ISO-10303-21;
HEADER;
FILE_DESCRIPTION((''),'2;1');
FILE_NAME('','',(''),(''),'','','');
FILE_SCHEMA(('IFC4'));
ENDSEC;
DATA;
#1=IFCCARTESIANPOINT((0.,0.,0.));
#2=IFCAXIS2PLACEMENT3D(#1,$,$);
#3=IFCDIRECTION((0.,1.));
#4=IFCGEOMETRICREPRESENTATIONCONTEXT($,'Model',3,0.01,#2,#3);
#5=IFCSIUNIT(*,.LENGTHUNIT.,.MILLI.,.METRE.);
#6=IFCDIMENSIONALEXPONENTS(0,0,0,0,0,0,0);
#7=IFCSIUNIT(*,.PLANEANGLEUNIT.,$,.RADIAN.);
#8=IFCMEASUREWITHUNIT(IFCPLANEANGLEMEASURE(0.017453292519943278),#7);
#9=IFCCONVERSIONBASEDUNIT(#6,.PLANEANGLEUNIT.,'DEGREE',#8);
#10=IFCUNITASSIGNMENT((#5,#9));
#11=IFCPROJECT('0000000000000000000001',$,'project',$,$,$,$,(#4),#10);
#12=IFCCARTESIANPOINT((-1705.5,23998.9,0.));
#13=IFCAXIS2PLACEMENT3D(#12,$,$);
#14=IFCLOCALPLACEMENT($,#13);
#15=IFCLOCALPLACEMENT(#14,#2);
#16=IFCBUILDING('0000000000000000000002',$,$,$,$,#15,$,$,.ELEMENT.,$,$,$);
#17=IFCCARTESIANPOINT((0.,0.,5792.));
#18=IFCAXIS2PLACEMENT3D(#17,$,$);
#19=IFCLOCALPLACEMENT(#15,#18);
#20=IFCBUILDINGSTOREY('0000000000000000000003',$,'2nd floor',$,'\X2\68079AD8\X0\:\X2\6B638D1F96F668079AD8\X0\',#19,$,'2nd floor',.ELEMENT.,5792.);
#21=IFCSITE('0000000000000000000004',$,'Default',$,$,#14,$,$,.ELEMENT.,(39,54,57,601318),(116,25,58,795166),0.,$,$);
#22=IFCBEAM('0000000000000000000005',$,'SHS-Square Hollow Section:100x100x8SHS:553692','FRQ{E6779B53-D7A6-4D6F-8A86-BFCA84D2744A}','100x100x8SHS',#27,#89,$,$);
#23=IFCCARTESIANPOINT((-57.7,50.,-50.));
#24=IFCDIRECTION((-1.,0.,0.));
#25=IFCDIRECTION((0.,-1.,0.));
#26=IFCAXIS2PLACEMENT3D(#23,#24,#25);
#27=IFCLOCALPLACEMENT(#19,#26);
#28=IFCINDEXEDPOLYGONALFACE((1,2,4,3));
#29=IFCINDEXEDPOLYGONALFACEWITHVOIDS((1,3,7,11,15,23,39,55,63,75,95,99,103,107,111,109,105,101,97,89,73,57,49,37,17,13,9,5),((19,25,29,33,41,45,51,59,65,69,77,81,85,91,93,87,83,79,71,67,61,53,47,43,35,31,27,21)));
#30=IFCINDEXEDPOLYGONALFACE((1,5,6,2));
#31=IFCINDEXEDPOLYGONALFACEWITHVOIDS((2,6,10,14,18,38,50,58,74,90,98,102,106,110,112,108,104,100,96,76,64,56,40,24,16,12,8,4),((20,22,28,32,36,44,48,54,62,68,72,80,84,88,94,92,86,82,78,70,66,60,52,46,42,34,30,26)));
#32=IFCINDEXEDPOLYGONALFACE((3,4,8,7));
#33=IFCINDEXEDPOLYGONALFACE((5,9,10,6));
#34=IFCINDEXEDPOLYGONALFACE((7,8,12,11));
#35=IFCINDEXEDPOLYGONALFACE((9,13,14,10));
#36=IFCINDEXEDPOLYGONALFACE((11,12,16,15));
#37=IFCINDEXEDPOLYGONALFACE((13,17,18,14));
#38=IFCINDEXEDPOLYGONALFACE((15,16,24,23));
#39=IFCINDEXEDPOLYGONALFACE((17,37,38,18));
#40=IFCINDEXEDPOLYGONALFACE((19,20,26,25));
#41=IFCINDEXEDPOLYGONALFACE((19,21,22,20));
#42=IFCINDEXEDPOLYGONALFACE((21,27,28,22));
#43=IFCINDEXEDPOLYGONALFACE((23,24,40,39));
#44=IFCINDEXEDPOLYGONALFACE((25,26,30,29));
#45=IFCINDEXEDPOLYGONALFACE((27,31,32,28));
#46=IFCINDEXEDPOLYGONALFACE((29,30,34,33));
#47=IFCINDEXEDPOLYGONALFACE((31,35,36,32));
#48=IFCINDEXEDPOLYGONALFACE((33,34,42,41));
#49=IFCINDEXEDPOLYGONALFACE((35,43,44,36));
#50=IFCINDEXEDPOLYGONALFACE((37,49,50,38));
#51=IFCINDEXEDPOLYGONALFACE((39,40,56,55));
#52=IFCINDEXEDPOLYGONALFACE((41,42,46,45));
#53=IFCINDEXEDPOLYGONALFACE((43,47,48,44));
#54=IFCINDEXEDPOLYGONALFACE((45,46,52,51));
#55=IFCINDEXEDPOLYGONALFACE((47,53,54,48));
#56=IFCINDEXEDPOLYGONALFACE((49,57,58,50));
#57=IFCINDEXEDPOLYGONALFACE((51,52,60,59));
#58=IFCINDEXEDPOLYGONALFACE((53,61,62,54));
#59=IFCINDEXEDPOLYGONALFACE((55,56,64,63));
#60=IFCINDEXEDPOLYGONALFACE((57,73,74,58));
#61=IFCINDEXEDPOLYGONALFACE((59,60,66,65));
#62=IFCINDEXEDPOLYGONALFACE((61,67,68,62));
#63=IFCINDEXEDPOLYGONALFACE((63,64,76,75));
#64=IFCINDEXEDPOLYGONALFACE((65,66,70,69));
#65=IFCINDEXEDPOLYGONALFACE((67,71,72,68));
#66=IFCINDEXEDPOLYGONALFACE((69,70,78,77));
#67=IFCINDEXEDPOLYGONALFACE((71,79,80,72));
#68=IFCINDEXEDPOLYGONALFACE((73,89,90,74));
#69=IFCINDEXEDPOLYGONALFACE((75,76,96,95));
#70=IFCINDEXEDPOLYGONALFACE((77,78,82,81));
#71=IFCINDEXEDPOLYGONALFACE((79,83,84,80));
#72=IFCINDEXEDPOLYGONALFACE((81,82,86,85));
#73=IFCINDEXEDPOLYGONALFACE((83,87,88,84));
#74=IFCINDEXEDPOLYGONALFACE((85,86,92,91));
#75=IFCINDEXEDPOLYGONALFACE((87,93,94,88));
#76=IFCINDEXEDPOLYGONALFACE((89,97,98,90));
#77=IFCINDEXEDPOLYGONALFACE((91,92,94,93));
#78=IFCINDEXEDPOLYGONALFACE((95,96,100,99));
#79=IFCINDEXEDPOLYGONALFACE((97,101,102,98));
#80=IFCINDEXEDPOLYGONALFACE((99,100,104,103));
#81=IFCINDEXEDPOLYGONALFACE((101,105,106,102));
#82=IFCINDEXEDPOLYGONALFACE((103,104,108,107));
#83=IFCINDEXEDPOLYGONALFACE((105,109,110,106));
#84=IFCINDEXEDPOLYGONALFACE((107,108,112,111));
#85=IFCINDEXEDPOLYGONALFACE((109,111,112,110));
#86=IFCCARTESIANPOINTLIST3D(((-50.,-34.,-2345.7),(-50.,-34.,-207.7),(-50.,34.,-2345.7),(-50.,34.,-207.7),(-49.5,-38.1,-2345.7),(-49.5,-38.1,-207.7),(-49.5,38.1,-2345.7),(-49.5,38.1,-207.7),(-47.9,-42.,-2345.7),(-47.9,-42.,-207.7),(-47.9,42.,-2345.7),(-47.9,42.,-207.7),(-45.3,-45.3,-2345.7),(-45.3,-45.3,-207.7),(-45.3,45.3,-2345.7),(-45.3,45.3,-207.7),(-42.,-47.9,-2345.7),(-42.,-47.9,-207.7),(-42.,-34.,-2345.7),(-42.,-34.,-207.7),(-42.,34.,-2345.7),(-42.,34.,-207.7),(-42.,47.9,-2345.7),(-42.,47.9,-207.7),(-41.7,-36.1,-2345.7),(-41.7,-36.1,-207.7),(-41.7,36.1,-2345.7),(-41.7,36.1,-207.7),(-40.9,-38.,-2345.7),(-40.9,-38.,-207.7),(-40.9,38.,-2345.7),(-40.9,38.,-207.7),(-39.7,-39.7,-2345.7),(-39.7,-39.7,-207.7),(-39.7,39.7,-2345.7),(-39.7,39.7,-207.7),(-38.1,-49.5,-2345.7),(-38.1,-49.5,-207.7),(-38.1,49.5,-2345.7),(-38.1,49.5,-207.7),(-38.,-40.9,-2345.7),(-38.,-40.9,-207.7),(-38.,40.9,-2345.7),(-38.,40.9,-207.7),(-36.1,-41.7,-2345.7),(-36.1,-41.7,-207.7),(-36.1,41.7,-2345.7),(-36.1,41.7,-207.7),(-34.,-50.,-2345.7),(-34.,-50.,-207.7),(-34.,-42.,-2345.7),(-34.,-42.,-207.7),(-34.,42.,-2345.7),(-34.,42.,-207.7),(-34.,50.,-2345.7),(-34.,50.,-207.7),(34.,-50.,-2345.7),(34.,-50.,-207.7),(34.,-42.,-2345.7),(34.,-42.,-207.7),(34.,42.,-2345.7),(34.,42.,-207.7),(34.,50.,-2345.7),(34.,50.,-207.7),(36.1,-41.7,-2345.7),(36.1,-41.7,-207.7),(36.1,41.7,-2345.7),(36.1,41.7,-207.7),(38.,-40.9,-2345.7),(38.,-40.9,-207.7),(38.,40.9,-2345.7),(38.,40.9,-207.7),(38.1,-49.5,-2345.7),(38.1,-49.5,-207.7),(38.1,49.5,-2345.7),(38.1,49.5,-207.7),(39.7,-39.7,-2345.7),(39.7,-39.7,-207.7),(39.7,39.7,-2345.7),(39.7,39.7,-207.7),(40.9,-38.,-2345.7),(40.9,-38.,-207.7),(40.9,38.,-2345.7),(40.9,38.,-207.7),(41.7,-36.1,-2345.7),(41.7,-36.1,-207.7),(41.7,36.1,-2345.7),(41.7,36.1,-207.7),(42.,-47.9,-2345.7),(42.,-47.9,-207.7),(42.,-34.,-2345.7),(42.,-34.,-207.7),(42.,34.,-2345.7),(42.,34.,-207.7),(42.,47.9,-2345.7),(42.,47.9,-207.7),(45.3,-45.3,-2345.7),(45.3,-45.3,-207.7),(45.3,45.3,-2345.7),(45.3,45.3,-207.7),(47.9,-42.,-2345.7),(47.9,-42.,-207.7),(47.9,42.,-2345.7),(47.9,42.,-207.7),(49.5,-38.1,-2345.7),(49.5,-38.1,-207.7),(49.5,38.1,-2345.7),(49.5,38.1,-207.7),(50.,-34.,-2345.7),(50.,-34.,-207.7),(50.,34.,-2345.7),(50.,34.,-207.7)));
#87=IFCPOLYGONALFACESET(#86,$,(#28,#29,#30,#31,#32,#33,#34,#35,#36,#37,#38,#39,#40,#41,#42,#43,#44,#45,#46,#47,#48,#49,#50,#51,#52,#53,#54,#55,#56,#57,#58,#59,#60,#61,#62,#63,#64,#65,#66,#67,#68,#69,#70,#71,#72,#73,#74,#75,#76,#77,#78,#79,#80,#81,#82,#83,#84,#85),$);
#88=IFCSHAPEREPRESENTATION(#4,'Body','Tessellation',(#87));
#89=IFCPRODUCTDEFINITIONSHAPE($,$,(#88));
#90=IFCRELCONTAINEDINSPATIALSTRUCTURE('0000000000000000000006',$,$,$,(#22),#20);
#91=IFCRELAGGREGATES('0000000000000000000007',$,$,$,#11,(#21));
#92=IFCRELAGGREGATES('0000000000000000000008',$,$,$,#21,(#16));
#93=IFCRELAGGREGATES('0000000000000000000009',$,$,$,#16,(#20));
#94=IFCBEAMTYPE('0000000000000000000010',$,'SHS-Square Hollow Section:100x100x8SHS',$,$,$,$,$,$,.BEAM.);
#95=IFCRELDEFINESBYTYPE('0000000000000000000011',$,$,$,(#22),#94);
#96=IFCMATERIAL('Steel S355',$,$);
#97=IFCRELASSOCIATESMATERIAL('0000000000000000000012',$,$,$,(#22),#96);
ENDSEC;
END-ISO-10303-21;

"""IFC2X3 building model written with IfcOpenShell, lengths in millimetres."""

from ifc_helpers import new_model, entity, si_unit, converted_unit, direction, frame, origin, origin_2d, place, context, project, spatial, hollow_rectangle, extrude, clip, halfspace, material, type_object, element, save


model = new_model("IFC2X3")

# Units and contexts
model_context = context("Model", 3, precision=0.01, world=origin(), true_north=direction((0.0, 1.0)))
ifc_project = project(units=[si_unit("LENGTHUNIT", "METRE", prefix="MILLI"), converted_unit("PLANEANGLEUNIT", "DEGREE", entity("IfcPlaneAngleMeasure", 0.017453292519943278), si_unit("PLANEANGLEUNIT", "RADIAN"), dimensions=[0, 0, 0, 0, 0, 0, 0])], contexts=[model_context])

# Site, building, storey
site_placement = place(None, frame((-1705.5, 23998.9, 0.0)))
site = spatial("IfcSite", under=ifc_project, at=site_placement, Name="Default", CompositionType="ELEMENT", RefLatitude=(39, 54, 57, 601318), RefLongitude=(116, 25, 58, 795166), RefElevation=0.0)
building_placement = place(site_placement, origin())
building = spatial("IfcBuilding", under=site, at=building_placement, CompositionType="ELEMENT")
storey_placement = place(building_placement, frame((0.0, 0.0, 5792.0)))
storey = spatial("IfcBuildingStorey", under=building, at=storey_placement, Name="2nd floor", ObjectType="标高:正负零标高", LongName="2nd floor", CompositionType="ELEMENT", Elevation=5792.0)

# Shared definitions
ifc_material_1 = material(Name="Steel S355")

# Beam
beam_type_1 = type_object("IfcBeamType", Name="SHS-Square Hollow Section:100x100x8SHS", PredefinedType="BEAM")
beam_1_placement = place(storey_placement, frame((-57.7, 50.0, -50.0), z_axis=(-1.0, 0.0, 0.0), x_axis=(0.0, -1.0, 0.0)))
element("IfcBeam", 1, at=beam_1_placement, inside=storey, type_object=beam_type_1, material=ifc_material_1, Name="SHS-Square Hollow Section:100x100x8SHS:553692", Description="FRQ{E6779B53-D7A6-4D6F-8A86-BFCA84D2744A}", ObjectType="100x100x8SHS", context=model_context, shape_type="Clipping", body=[
    clip(clip(extrude(hollow_rectangle(XDim=100.0, YDim=100.0, WallThickness=8.0, InnerFilletRadius=8.0, OuterFilletRadius=16.0, at=origin_2d()), origin(), (0.0, 0.0, -1.0), 2551.4), halfspace(frame((50.0, -5742.0, -207.7), z_axis=(0.0, 0.0, -1.0), x_axis=(-1.0, 0.0, 0.0)), True)), halfspace(frame((50.0, -5742.0, -2345.7), z_axis=(0.0, 0.0, 1.0), x_axis=(1.0, 0.0, 0.0)), True)),
])

save(model, "model.ifc")
